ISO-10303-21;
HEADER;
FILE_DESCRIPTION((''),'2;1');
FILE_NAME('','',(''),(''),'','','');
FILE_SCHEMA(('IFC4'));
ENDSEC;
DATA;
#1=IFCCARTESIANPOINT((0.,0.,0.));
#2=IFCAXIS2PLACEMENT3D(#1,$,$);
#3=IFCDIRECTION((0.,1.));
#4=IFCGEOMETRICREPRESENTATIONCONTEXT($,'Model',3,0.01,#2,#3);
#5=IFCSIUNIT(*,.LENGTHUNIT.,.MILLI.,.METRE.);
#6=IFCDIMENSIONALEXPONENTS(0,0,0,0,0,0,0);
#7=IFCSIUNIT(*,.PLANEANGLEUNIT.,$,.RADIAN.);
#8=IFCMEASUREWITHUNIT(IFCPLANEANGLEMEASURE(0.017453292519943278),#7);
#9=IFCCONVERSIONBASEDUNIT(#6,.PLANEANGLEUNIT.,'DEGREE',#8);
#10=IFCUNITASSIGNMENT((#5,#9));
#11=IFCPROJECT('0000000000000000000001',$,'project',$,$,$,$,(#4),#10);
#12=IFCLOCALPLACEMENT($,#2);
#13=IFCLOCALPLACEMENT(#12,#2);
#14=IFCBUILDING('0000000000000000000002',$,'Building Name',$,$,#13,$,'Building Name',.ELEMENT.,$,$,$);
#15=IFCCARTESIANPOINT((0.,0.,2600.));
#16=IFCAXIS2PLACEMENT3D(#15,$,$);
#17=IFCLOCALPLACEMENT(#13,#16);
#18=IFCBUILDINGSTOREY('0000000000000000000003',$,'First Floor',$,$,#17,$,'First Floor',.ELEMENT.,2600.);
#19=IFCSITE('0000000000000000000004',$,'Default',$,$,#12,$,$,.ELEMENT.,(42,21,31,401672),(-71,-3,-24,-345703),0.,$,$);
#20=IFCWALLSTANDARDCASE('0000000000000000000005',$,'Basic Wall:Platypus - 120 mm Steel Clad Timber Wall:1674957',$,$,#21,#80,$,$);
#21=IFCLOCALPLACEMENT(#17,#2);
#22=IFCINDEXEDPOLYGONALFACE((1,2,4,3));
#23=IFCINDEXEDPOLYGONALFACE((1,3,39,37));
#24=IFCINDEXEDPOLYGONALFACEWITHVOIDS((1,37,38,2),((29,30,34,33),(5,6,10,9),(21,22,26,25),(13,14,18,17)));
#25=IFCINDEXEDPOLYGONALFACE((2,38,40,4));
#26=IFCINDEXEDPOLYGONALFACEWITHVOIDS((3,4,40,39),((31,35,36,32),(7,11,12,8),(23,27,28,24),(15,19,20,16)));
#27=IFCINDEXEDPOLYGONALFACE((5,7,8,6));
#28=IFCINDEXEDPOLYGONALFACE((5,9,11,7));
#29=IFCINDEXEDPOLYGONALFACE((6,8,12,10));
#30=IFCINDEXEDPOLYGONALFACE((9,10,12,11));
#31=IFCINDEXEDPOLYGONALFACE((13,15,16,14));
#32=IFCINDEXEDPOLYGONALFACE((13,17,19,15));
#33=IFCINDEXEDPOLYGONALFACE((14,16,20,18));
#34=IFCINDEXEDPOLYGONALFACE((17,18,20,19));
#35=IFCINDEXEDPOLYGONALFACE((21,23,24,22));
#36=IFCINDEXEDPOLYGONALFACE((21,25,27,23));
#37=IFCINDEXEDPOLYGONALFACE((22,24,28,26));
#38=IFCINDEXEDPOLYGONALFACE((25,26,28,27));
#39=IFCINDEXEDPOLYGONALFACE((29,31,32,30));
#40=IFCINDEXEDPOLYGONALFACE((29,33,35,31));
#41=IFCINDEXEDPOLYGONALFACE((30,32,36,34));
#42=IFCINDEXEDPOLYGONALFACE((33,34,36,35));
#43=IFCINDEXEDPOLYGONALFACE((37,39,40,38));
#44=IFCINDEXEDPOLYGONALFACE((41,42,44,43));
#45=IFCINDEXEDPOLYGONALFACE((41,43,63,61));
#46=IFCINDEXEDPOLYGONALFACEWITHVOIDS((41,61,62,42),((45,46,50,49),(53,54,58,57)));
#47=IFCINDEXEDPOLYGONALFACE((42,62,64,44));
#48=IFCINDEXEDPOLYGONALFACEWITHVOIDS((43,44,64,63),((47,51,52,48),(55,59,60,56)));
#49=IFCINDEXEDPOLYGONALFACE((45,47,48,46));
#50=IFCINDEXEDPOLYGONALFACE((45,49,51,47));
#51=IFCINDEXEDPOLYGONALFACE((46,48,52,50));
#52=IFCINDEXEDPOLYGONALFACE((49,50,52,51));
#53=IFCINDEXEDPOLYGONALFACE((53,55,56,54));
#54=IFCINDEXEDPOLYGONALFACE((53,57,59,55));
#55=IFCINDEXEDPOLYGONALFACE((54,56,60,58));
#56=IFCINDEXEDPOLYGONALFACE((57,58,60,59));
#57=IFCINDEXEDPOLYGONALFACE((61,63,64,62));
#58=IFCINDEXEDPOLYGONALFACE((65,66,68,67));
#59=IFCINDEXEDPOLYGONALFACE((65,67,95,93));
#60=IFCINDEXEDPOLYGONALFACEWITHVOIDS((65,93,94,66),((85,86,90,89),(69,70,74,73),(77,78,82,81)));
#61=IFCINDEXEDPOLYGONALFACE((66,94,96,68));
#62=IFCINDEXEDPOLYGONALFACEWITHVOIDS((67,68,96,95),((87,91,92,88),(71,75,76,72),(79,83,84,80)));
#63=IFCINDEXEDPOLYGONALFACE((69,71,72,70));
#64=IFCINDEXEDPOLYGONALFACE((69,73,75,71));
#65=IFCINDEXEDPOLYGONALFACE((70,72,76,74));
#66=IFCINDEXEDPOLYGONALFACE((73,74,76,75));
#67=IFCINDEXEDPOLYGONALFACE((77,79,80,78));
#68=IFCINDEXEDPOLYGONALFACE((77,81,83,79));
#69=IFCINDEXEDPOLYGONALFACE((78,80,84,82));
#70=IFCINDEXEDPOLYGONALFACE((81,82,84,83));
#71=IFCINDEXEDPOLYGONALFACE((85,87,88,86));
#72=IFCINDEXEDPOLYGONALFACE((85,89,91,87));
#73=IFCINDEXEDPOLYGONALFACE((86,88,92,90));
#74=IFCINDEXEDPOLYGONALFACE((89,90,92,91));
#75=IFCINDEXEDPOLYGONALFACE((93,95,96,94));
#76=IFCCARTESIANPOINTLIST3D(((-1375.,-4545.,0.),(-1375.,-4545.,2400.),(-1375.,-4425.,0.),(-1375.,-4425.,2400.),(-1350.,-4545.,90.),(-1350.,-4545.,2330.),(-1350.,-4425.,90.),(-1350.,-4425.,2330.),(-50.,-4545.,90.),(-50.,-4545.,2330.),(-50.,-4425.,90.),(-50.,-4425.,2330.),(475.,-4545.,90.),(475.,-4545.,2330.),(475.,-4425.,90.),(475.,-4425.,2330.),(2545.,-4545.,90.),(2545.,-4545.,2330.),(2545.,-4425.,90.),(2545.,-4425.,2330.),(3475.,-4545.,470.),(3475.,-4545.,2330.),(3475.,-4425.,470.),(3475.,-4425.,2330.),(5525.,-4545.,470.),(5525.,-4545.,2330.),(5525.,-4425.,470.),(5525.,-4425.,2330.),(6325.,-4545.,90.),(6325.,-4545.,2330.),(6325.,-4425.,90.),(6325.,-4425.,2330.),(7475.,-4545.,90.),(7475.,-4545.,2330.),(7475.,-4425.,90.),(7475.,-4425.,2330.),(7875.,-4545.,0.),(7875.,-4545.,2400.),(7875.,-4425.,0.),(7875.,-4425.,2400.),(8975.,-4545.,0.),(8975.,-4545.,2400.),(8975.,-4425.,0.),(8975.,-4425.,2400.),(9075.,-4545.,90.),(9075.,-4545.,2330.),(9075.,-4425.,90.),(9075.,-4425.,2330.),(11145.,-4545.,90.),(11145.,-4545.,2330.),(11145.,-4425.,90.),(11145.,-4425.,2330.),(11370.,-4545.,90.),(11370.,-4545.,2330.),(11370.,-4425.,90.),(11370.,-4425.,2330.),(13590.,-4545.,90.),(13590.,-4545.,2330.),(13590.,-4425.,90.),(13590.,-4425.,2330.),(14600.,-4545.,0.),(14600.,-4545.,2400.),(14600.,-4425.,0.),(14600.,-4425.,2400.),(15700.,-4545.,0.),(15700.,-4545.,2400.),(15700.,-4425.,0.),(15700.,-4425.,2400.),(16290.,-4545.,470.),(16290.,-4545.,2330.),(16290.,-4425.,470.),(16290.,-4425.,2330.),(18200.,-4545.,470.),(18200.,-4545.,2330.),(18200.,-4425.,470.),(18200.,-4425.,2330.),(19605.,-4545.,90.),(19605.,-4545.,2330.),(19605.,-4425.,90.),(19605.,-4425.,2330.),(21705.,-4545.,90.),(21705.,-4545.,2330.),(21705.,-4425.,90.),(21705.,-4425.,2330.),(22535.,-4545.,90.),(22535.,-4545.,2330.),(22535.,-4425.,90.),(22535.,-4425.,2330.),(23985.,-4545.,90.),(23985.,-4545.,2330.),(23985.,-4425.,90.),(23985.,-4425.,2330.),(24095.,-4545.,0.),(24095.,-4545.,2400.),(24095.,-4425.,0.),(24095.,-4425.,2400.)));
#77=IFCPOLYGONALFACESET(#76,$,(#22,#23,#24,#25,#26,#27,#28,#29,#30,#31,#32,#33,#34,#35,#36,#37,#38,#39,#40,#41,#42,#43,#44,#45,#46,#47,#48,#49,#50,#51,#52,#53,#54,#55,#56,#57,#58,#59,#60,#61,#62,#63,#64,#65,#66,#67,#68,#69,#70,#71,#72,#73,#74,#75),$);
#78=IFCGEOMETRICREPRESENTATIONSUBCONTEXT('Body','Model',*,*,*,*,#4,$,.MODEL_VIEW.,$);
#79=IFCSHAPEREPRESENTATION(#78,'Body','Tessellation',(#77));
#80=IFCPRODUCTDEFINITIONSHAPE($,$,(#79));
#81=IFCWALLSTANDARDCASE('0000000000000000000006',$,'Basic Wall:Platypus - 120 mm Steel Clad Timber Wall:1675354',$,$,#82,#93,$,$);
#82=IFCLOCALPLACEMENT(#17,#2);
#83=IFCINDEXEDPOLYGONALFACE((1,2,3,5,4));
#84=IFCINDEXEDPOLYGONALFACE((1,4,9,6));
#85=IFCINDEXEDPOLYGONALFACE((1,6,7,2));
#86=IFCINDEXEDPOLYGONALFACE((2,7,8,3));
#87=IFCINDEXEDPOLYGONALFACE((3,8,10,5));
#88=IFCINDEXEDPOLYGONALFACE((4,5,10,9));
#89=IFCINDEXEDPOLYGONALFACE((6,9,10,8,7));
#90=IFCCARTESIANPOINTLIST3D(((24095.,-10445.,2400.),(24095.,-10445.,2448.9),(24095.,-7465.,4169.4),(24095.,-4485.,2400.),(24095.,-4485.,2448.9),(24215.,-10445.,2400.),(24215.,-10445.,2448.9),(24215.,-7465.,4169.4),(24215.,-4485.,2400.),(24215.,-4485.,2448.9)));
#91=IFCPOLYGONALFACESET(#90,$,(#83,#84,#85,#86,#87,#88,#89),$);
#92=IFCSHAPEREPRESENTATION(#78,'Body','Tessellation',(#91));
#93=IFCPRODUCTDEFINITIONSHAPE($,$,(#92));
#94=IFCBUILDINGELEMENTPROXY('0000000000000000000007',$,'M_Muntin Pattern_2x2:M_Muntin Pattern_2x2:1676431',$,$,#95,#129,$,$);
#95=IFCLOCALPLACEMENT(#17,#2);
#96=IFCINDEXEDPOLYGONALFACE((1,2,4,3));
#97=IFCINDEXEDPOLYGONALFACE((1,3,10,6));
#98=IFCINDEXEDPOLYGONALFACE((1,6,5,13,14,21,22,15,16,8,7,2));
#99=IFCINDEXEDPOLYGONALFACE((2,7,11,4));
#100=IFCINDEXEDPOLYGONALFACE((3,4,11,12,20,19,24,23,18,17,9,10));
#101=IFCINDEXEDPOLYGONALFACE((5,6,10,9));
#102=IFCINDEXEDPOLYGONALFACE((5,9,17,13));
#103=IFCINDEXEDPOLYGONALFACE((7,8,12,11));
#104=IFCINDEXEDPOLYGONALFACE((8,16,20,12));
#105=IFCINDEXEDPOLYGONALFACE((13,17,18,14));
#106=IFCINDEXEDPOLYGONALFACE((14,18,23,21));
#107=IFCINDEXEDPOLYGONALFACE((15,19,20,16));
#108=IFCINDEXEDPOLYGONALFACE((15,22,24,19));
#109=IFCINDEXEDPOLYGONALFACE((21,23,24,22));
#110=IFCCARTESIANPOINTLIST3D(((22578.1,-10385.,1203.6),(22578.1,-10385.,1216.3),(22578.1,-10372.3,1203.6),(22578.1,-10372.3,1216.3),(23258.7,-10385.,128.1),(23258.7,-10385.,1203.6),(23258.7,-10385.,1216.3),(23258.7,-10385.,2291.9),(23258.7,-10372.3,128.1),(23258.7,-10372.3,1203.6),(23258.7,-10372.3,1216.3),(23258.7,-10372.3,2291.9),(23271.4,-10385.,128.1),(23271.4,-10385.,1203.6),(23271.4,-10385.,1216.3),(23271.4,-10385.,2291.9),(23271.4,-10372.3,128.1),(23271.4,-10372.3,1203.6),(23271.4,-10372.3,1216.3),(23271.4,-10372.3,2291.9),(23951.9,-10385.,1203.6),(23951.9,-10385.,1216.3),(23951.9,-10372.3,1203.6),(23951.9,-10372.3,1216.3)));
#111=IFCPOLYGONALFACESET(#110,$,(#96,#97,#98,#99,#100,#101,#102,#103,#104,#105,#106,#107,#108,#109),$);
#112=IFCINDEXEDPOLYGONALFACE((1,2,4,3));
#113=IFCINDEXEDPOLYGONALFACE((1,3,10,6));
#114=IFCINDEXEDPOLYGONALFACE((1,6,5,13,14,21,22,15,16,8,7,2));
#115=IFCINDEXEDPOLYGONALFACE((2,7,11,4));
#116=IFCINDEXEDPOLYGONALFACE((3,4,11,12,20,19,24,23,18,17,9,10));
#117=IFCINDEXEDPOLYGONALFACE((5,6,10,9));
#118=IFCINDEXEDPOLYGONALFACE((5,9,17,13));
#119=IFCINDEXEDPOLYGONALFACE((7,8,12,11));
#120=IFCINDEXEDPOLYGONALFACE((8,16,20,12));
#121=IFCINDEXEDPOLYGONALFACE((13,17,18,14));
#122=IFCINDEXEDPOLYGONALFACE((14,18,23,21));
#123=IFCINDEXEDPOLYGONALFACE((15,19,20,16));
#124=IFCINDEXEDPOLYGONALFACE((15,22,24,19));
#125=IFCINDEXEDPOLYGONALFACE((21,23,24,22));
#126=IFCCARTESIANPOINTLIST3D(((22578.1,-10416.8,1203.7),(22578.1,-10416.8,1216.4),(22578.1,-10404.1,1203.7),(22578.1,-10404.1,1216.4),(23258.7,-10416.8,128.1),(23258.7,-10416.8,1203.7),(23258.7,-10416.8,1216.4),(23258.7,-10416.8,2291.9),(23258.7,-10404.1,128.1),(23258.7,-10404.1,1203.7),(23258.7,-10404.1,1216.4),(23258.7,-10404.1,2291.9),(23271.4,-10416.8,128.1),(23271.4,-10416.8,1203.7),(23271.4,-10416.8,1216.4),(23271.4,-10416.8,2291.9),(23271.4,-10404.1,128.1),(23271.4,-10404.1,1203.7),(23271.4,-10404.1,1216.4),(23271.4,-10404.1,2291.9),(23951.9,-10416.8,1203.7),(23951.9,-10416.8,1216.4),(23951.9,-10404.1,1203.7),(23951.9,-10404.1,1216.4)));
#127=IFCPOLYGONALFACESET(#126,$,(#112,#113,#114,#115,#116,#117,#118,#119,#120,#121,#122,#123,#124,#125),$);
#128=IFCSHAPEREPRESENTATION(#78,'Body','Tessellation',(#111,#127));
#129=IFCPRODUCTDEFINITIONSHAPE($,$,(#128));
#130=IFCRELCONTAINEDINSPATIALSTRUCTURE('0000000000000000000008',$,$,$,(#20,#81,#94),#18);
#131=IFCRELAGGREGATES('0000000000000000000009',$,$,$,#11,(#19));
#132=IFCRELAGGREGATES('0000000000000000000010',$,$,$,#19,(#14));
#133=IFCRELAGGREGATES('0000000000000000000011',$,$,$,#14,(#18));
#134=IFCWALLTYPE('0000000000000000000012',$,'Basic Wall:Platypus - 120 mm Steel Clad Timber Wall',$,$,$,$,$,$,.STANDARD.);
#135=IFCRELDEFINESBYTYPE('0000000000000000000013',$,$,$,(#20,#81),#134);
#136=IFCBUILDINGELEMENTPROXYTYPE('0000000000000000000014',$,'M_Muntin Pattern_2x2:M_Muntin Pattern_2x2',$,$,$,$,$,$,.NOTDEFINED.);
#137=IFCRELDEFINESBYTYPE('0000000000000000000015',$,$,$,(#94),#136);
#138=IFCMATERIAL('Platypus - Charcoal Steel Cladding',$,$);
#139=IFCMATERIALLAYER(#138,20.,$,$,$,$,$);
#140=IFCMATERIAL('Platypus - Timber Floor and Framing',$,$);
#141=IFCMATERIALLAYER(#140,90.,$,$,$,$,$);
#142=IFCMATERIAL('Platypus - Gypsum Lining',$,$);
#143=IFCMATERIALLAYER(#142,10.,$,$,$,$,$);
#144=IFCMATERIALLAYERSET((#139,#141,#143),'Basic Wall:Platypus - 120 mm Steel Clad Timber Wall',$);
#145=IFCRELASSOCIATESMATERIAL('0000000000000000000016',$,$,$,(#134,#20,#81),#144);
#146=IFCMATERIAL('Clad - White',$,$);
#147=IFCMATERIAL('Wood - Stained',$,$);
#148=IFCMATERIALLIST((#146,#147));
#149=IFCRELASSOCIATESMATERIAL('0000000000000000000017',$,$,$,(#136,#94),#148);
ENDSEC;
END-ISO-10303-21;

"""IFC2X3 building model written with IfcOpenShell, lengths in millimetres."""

from ifc_helpers import new_model, entity, si_unit, converted_unit, direction, frame, frame_2d, origin, place, context, subcontext, project, spatial, polyline, rectangle, outline, extrude, clip, halfspace, source, transform, mapped, material, material_list, layer, layer_set, layer_usage, type_object, type_shapes, element, save


model = new_model("IFC2X3")

# Units and contexts
model_context = context("Model", 3, precision=0.01, world=origin(), true_north=direction((0.0, 1.0)))
body_context = subcontext(model_context, "Body", "Model", "MODEL_VIEW")
ifc_project = project(units=[si_unit("LENGTHUNIT", "METRE", prefix="MILLI"), converted_unit("PLANEANGLEUNIT", "DEGREE", entity("IfcPlaneAngleMeasure", 0.017453292519943278), si_unit("PLANEANGLEUNIT", "RADIAN"), dimensions=[0, 0, 0, 0, 0, 0, 0])], contexts=[model_context])

# Site, building, storey
site_placement = place(None, origin())
site = spatial("IfcSite", under=ifc_project, at=site_placement, Name="Default", CompositionType="ELEMENT", RefLatitude=(42, 21, 31, 401672), RefLongitude=(-71, -3, -24, -345703), RefElevation=0.0)
building_placement = place(site_placement, origin())
building = spatial("IfcBuilding", under=site, at=building_placement, Name="Building Name", LongName="Building Name", CompositionType="ELEMENT")
storey_placement = place(building_placement, frame((0.0, 0.0, 2600.0)))
storey = spatial("IfcBuildingStorey", under=building, at=storey_placement, Name="First Floor", LongName="First Floor", CompositionType="ELEMENT", Elevation=2600.0)

# Shared definitions
ifc_material_1 = material(Name="Platypus - Charcoal Steel Cladding")
ifc_layer_1 = layer(ifc_material_1, 20.0)
ifc_material_2 = material(Name="Platypus - Timber Floor and Framing")
ifc_layer_2 = layer(ifc_material_2, 90.0)
ifc_material_3 = material(Name="Platypus - Gypsum Lining")
ifc_layer_3 = layer(ifc_material_3, 10.0)
ifc_layer_set_1 = layer_set([ifc_layer_1, ifc_layer_2, ifc_layer_3], Name="Basic Wall:Platypus - 120 mm Steel Clad Timber Wall")
wall_type = type_object("IfcWallType", Name="Basic Wall:Platypus - 120 mm Steel Clad Timber Wall", PredefinedType="STANDARD", material=ifc_layer_set_1)

# Wall, openings
ifc_layer_usage_1 = layer_usage(ifc_layer_set_1, "AXIS2", "POSITIVE", -60.0)
wall_1_placement = place(storey_placement, frame((24095.0, -4485.0, 0.0), z_axis=(0.0, 0.0, 1.0), x_axis=(-1.0, 0.0, 0.0)))
wall_1 = element("IfcWallStandardCase", 1, at=wall_1_placement, inside=storey, type_object=wall_type, material=ifc_layer_usage_1, Name="Basic Wall:Platypus - 120 mm Steel Clad Timber Wall:1674957", context=body_context, shape_type="SweptSolid", body=[
    extrude(rectangle(XDim=25470.0, YDim=120.0, at=frame_2d((12735.0, 0.0), x_axis=(-1.0, 0.0))), origin(), (0.0, 0.0, 1.0), 2400.0),
])
opening_1_placement = place(wall_1_placement, frame((8395.0, -60.0, 0.0)))
element("IfcOpeningElement", 2, at=opening_1_placement, cuts=wall_1, ObjectType="Opening", context=body_context, shape_type="SweptSolid", body=[
    extrude(rectangle(XDim=2440.0, YDim=1100.0, at=frame_2d((1220.0, 550.0), x_axis=(1.0, 0.0))), frame((0.0, 0.0, 0.0), z_axis=(0.0, 1.0, 0.0), x_axis=(0.0, 0.0, 1.0)), (0.0, 0.0, 1.0), 120.0),
])
opening_2_placement = place(wall_1_placement, frame((15120.0, -60.0, 0.0)))
element("IfcOpeningElement", 3, at=opening_2_placement, cuts=wall_1, ObjectType="Opening", context=body_context, shape_type="SweptSolid", body=[
    extrude(rectangle(XDim=2440.0, YDim=1100.0, at=frame_2d((1220.0, 550.0), x_axis=(1.0, 0.0))), frame((0.0, 0.0, 0.0), z_axis=(0.0, 1.0, 0.0), x_axis=(0.0, 0.0, 1.0)), (0.0, 0.0, 1.0), 120.0),
])
opening_3_placement = place(wall_1_placement, frame((24145.0, -60.0, 90.0)))
element("IfcOpeningElement", 4, at=opening_3_placement, cuts=wall_1, ObjectType="Opening", context=body_context, shape_type="SweptSolid", body=[
    extrude(rectangle(XDim=2240.0, YDim=1300.0, at=frame_2d((1120.0, 650.0), x_axis=(-1.0, 0.0))), frame((0.0, 0.0, 0.0), z_axis=(0.0, 1.0, 0.0), x_axis=(0.0, 0.0, 1.0)), (0.0, 0.0, 1.0), 120.0),
])
opening_4_placement = place(wall_1_placement, frame((21550.0, -60.0, 90.0)))
element("IfcOpeningElement", 5, at=opening_4_placement, cuts=wall_1, ObjectType="Opening", context=body_context, shape_type="SweptSolid", body=[
    extrude(rectangle(XDim=2240.0, YDim=2070.0, at=frame_2d((1120.0, 1035.0), x_axis=(-1.0, 0.0))), frame((0.0, 0.0, 0.0), z_axis=(0.0, 1.0, 0.0), x_axis=(0.0, 0.0, 1.0)), (0.0, 0.0, 1.0), 120.0),
])
opening_5_placement = place(wall_1_placement, frame((18570.0, -60.0, 470.0)))
element("IfcOpeningElement", 6, at=opening_5_placement, cuts=wall_1, ObjectType="Opening", context=body_context, shape_type="SweptSolid", body=[
    extrude(rectangle(XDim=1860.0, YDim=2050.0, at=frame_2d((930.0, 1025.0), x_axis=(-1.0, 0.0))), frame((0.0, 0.0, 0.0), z_axis=(0.0, 1.0, 0.0), x_axis=(0.0, 0.0, 1.0)), (0.0, 0.0, 1.0), 120.0),
])
opening_6_placement = place(wall_1_placement, frame((16620.0, -60.0, 90.0)))
element("IfcOpeningElement", 7, at=opening_6_placement, cuts=wall_1, ObjectType="Opening", context=body_context, shape_type="SweptSolid", body=[
    extrude(rectangle(XDim=2240.0, YDim=1150.0, at=frame_2d((1120.0, 575.0), x_axis=(-1.0, 0.0))), frame((0.0, 0.0, 0.0), z_axis=(0.0, 1.0, 0.0), x_axis=(0.0, 0.0, 1.0)), (0.0, 0.0, 1.0), 120.0),
])
opening_7_placement = place(wall_1_placement, frame((12950.0, -60.0, 90.0)))
element("IfcOpeningElement", 8, at=opening_7_placement, cuts=wall_1, ObjectType="Opening", context=body_context, shape_type="SweptSolid", body=[
    extrude(rectangle(XDim=2240.0, YDim=2070.0, at=frame_2d((1120.0, 1035.0), x_axis=(-1.0, 0.0))), frame((0.0, 0.0, 0.0), z_axis=(0.0, 1.0, 0.0), x_axis=(0.0, 0.0, 1.0)), (0.0, 0.0, 1.0), 120.0),
])
opening_8_placement = place(wall_1_placement, frame((10505.0, -60.0, 90.0)))
element("IfcOpeningElement", 9, at=opening_8_placement, cuts=wall_1, ObjectType="Opening", context=body_context, shape_type="SweptSolid", body=[
    extrude(rectangle(XDim=2240.0, YDim=2220.0, at=frame_2d((1120.0, 1110.0), x_axis=(-1.0, 0.0))), frame((0.0, 0.0, 0.0), z_axis=(0.0, 1.0, 0.0), x_axis=(0.0, 0.0, 1.0)), (0.0, 0.0, 1.0), 120.0),
])
opening_9_placement = place(wall_1_placement, frame((5895.0, -60.0, 470.0)))
element("IfcOpeningElement", 10, at=opening_9_placement, cuts=wall_1, ObjectType="Opening", context=body_context, shape_type="SweptSolid", body=[
    extrude(rectangle(XDim=1860.0, YDim=1910.0, at=frame_2d((930.0, 955.0), x_axis=(-1.0, 0.0))), frame((0.0, 0.0, 0.0), z_axis=(0.0, 1.0, 0.0), x_axis=(0.0, 0.0, 1.0)), (0.0, 0.0, 1.0), 120.0),
])
opening_10_placement = place(wall_1_placement, frame((2390.0, -60.0, 90.0)))
element("IfcOpeningElement", 11, at=opening_10_placement, cuts=wall_1, ObjectType="Opening", context=body_context, shape_type="SweptSolid", body=[
    extrude(rectangle(XDim=2240.0, YDim=2100.0, at=frame_2d((1120.0, 1050.0), x_axis=(-1.0, 0.0))), frame((0.0, 0.0, 0.0), z_axis=(0.0, 1.0, 0.0), x_axis=(0.0, 0.0, 1.0)), (0.0, 0.0, 1.0), 120.0),
])
opening_11_placement = place(wall_1_placement, frame((110.0, -60.0, 90.0)))
element("IfcOpeningElement", 12, at=opening_11_placement, cuts=wall_1, ObjectType="Opening", context=body_context, shape_type="SweptSolid", body=[
    extrude(rectangle(XDim=2240.0, YDim=1450.0, at=frame_2d((1120.0, 725.0), x_axis=(-1.0, 0.0))), frame((0.0, 0.0, 0.0), z_axis=(0.0, 1.0, 0.0), x_axis=(0.0, 0.0, 1.0)), (0.0, 0.0, 1.0), 120.0),
])

# Wall
ifc_layer_usage_2 = layer_usage(ifc_layer_set_1, "AXIS2", "POSITIVE", -60.0)
wall_2_placement = place(storey_placement, frame((24155.0, -10445.0, 2400.0), z_axis=(0.0, 0.0, 1.0), x_axis=(0.0, 1.0, 0.0)))
element("IfcWallStandardCase", 13, at=wall_2_placement, inside=storey, type_object=wall_type, material=ifc_layer_usage_2, Name="Basic Wall:Platypus - 120 mm Steel Clad Timber Wall:1675354", context=body_context, shape_type="Clipping", body=[
    clip(clip(extrude(rectangle(XDim=5960.0, YDim=120.0, at=frame_2d((2980.0, 0.0), x_axis=(-1.0, 0.0))), origin(), (0.0, 0.0, 1.0), 1769.4), halfspace(frame((2980.0, -60.0, 1769.4), z_axis=(0.5, 0.0, 0.866025), x_axis=(0.0, 1.0, 0.0)), False)), halfspace(frame((0.0, -60.0, 48.9), z_axis=(-0.5, 0.0, 0.866025), x_axis=(0.0, 1.0, 0.0)), False)),
])

# Building element proxy
ifc_material_4 = material(Name="Clad - White")
ifc_material_5 = material(Name="Wood - Stained")
ifc_material_list = material_list([ifc_material_4, ifc_material_5])
building_element_proxy_type_1 = type_object("IfcBuildingElementProxyType", Name="M_Muntin Pattern_2x2:M_Muntin Pattern_2x2", PredefinedType="NOTDEFINED", material=ifc_material_list)
shared_shape_1 = source(origin(), body_context, "Body", "SweptSolid", [
    extrude(outline(polyline([(6.4, -6.4), (1081.9, -6.4), (1081.9, 6.3), (6.4, 6.3), (6.4, 686.9), (-6.3, 686.9), (-6.3, 6.3), (-1081.9, 6.3), (-1081.9, -6.4), (-6.3, -6.4), (-6.3, -686.9), (6.4, -686.9), (6.4, -6.4)])), frame((0.0, -22.2, 1081.9), z_axis=(0.0, 1.0, 0.0), x_axis=(0.0, 0.0, 1.0)), (0.0, 0.0, 1.0), 12.7),
    extrude(outline(polyline([(6.4, -6.4), (1081.9, -6.4), (1081.9, 6.3), (6.4, 6.3), (6.4, 686.9), (-6.3, 686.9), (-6.3, 6.3), (-1081.9, 6.3), (-1081.9, -6.4), (-6.3, -6.4), (-6.3, -686.9), (6.4, -686.9), (6.4, -6.4)])), frame((0.0, 9.5, 1081.9), z_axis=(0.0, 1.0, 0.0), x_axis=(0.0, 0.0, 1.0)), (0.0, 0.0, 1.0), 12.7),
])
type_shapes(building_element_proxy_type_1, [shared_shape_1])
proxy_1_placement = place(storey_placement, frame((23265.0, -10394.5, 128.1), z_axis=(0.0, 0.0, 1.0), x_axis=(-1.0, 0.0, 0.0)))
element("IfcBuildingElementProxy", 14, at=proxy_1_placement, inside=storey, type_object=building_element_proxy_type_1, material=ifc_material_list, Name="M_Muntin Pattern_2x2:M_Muntin Pattern_2x2:1676431", context=body_context, shape_type="MappedRepresentation", body=[
    mapped(shared_shape_1, transform((0.0, 0.0, 0.0), scale=1.0)),
])

save(model, "model.ifc")
